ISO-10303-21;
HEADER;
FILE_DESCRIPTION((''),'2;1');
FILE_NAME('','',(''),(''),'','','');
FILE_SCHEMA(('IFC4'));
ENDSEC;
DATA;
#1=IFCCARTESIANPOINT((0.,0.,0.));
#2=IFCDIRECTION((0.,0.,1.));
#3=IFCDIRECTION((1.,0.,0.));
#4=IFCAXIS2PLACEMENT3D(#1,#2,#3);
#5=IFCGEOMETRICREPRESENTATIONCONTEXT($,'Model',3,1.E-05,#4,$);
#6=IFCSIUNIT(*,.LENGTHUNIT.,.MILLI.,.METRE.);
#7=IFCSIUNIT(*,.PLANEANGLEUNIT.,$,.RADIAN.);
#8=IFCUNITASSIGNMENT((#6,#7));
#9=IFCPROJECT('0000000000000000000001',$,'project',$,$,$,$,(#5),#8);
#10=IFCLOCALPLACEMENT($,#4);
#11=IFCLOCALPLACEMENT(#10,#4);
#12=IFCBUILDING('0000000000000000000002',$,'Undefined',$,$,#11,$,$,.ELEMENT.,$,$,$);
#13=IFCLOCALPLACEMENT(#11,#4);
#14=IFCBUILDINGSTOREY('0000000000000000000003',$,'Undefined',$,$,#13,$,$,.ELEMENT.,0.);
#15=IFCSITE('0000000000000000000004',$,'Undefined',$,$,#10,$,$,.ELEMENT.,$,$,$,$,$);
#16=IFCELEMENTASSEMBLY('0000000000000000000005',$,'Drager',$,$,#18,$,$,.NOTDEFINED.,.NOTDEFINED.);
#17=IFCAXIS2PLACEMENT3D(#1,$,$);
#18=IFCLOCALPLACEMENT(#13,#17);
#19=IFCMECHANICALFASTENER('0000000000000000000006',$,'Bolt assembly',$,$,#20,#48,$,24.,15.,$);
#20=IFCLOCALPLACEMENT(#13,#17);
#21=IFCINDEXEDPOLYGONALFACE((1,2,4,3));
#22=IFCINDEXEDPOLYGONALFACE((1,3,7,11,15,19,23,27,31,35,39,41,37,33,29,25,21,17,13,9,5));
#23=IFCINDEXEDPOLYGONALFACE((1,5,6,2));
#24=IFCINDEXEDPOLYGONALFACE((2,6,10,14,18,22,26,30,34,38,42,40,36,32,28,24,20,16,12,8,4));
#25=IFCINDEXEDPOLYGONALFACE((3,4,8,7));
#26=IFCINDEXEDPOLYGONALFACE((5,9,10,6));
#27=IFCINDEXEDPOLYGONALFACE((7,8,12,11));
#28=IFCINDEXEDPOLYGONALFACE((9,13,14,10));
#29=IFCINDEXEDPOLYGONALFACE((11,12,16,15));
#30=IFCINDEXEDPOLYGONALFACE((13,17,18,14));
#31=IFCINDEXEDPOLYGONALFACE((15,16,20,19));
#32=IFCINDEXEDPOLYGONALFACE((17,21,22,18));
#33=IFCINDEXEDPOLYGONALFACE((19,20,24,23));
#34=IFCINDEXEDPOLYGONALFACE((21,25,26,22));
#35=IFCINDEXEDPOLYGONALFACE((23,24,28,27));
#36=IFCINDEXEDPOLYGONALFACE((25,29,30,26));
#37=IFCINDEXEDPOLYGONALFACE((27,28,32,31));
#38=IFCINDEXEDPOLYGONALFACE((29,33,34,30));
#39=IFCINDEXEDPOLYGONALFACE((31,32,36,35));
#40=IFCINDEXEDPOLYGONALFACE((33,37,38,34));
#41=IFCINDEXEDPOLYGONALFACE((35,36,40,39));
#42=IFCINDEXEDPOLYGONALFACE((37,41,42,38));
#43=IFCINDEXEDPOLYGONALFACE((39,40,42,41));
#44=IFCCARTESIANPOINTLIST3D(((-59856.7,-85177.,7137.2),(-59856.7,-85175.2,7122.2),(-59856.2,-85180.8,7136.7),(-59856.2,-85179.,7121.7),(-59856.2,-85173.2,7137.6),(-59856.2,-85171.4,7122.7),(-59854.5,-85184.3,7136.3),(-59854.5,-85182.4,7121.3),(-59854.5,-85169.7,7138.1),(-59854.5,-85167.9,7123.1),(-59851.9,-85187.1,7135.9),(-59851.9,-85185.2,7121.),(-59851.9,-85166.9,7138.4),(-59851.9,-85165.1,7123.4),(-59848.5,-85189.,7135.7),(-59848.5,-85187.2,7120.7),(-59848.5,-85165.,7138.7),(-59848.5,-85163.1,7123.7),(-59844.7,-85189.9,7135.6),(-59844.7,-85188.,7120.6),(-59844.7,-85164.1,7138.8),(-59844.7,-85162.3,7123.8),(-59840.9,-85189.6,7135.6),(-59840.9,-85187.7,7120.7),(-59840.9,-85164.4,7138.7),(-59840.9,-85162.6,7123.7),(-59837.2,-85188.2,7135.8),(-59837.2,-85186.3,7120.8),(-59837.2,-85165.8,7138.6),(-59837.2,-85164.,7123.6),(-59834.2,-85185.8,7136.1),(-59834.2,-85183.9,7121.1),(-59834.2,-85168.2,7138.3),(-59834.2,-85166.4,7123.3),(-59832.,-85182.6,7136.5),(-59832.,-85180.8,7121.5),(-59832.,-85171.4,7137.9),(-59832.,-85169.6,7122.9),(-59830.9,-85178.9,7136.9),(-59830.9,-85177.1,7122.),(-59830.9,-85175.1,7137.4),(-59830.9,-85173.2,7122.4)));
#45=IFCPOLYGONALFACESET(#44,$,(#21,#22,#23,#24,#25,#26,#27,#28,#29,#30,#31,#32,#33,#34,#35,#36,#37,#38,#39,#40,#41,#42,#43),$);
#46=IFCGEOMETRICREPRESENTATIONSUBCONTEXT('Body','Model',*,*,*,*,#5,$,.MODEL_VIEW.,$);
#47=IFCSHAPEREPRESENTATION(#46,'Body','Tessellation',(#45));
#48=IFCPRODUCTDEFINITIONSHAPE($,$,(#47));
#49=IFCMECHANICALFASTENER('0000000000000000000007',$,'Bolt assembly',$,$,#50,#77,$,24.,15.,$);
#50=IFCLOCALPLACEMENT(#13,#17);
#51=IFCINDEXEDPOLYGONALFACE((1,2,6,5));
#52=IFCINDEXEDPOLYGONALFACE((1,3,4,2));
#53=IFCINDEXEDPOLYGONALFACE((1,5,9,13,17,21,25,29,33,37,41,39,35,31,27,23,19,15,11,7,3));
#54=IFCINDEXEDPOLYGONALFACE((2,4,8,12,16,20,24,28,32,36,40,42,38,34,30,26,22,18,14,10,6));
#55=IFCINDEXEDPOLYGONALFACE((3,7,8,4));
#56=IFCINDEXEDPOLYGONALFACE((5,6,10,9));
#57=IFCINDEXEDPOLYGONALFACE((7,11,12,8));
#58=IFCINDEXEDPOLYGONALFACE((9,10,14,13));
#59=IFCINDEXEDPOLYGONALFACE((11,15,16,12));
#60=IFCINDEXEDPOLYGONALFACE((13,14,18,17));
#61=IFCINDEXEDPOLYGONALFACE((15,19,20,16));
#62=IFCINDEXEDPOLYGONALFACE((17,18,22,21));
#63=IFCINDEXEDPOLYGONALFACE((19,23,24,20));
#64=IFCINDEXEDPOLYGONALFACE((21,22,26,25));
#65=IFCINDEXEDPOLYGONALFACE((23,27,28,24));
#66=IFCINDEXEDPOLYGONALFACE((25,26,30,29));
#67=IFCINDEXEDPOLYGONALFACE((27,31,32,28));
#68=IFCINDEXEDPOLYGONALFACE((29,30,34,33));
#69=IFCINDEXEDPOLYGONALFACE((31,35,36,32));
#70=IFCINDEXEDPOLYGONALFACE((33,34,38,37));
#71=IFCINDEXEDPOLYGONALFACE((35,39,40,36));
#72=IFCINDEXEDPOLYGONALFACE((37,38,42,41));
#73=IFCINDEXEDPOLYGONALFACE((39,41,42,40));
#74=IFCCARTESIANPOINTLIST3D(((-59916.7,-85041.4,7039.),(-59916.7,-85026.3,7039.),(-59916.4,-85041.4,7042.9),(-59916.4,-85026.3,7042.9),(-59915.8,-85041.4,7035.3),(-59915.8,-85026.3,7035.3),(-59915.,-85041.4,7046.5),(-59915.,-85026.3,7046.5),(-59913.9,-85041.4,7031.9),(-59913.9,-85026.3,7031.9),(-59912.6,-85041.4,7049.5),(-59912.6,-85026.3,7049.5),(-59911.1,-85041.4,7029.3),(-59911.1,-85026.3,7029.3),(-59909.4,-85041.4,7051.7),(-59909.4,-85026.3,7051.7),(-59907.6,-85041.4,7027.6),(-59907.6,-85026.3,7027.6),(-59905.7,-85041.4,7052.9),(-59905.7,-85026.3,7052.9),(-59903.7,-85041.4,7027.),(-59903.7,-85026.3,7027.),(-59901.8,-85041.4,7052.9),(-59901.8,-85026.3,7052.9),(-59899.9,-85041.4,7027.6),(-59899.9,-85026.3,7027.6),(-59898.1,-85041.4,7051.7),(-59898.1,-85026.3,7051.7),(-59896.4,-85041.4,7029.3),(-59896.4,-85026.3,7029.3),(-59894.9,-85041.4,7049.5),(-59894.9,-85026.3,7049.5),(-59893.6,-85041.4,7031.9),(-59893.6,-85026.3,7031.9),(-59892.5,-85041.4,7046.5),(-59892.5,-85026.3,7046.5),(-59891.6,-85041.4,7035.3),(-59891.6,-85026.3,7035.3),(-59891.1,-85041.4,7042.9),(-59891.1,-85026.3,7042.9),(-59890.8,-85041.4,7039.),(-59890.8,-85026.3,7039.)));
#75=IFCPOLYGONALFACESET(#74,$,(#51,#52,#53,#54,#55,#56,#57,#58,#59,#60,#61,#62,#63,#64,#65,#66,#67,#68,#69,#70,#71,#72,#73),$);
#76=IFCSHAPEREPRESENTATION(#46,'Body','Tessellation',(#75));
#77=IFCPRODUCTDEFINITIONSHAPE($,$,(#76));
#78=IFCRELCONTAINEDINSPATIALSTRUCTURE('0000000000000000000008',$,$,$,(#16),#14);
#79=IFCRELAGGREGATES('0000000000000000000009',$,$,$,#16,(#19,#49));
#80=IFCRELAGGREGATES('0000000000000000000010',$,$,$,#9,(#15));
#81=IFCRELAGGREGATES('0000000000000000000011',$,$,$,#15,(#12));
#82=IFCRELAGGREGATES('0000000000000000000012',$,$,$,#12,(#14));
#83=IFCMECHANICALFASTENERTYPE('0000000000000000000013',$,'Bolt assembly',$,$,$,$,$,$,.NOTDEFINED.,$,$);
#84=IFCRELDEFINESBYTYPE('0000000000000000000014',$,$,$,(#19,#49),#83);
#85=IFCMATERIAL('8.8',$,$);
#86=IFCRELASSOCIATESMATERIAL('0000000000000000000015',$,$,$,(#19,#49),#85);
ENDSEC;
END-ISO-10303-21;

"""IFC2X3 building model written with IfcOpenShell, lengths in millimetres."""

from ifc_helpers import new_model, si_unit, frame, origin_with_axes, origin_2d_with_axis, place, context, subcontext, project, spatial, circle, extrude, source, transform, mapped, material, type_object, element, aggregate, save


model = new_model("IFC2X3")

# Units and contexts
model_context = context("Model", 3, precision=1e-05, world=origin_with_axes())
body_context = subcontext(model_context, "Body", "Model", "MODEL_VIEW")
ifc_project = project(units=[si_unit("LENGTHUNIT", "METRE", prefix="MILLI"), si_unit("PLANEANGLEUNIT", "RADIAN")], contexts=[model_context])

# Site, building, storey
site_placement = place(None, origin_with_axes())
site = spatial("IfcSite", under=ifc_project, at=site_placement, Name="Undefined", CompositionType="ELEMENT")
building_placement = place(site_placement, origin_with_axes())
building = spatial("IfcBuilding", under=site, at=building_placement, Name="Undefined", CompositionType="ELEMENT")
storey_placement = place(building_placement, origin_with_axes())
storey = spatial("IfcBuildingStorey", under=building, at=storey_placement, Name="Undefined", CompositionType="ELEMENT", Elevation=0.0)

# Element assembly
assembly_1_placement = place(storey_placement, origin_with_axes())
assembly_1 = element("IfcElementAssembly", 1, at=assembly_1_placement, inside=storey, Name="Drager", AssemblyPlace="NOTDEFINED", PredefinedType="NOTDEFINED")

# Mechanical fasteners
ifc_material_1 = material(Name="8.8")
mechanical_fastener_type = type_object("IfcMechanicalFastenerType", Name="Bolt assembly")
shared_shape_1 = source(origin_with_axes(), body_context, "Body", "SweptSolid", [
    extrude(circle(Radius=13.0, at=origin_2d_with_axis()), frame((0.0, -7.5, 0.0), z_axis=(0.0, 1.0, 0.0), x_axis=(1.0, 0.0, 0.0)), (0.0, 0.0, 1.0), 15.1),
])
mechanical_fastener_1_placement = place(assembly_1_placement, frame((-59843.7, -85176.1, 7129.7), z_axis=(0.0, -0.992546, -0.121869), x_axis=(-1.0, 0.0, 0.0)))
mechanical_fastener_1 = element("IfcMechanicalFastener", 2, at=mechanical_fastener_1_placement, type_object=mechanical_fastener_type, material=ifc_material_1, Name="Bolt assembly", NominalDiameter=24.0, NominalLength=15.0, context=body_context, shape_type="MappedRepresentation", body=[
    mapped(shared_shape_1, transform((0.0, 0.0, 0.0))),
])
shared_shape_2 = source(origin_with_axes(), body_context, "Body", "SweptSolid", [
    extrude(circle(Radius=13.0, at=origin_2d_with_axis()), frame((0.0, -7.4, 0.0), z_axis=(0.0, 1.0, 0.0), x_axis=(1.0, 0.0, 0.0)), (0.0, 0.0, 1.0), 15.1),
])
mechanical_fastener_2_placement = place(assembly_1_placement, frame((-59903.7, -85034.0, 7040.0), z_axis=(1.0, 0.0, 0.0), x_axis=(0.0, 0.0, -1.0)))
mechanical_fastener_2 = element("IfcMechanicalFastener", 3, at=mechanical_fastener_2_placement, type_object=mechanical_fastener_type, material=ifc_material_1, Name="Bolt assembly", NominalDiameter=24.0, NominalLength=15.0, context=body_context, shape_type="MappedRepresentation", body=[
    mapped(shared_shape_2, transform((0.0, 0.0, 0.0))),
])
aggregate(assembly_1, [mechanical_fastener_1, mechanical_fastener_2])

save(model, "model.ifc")
